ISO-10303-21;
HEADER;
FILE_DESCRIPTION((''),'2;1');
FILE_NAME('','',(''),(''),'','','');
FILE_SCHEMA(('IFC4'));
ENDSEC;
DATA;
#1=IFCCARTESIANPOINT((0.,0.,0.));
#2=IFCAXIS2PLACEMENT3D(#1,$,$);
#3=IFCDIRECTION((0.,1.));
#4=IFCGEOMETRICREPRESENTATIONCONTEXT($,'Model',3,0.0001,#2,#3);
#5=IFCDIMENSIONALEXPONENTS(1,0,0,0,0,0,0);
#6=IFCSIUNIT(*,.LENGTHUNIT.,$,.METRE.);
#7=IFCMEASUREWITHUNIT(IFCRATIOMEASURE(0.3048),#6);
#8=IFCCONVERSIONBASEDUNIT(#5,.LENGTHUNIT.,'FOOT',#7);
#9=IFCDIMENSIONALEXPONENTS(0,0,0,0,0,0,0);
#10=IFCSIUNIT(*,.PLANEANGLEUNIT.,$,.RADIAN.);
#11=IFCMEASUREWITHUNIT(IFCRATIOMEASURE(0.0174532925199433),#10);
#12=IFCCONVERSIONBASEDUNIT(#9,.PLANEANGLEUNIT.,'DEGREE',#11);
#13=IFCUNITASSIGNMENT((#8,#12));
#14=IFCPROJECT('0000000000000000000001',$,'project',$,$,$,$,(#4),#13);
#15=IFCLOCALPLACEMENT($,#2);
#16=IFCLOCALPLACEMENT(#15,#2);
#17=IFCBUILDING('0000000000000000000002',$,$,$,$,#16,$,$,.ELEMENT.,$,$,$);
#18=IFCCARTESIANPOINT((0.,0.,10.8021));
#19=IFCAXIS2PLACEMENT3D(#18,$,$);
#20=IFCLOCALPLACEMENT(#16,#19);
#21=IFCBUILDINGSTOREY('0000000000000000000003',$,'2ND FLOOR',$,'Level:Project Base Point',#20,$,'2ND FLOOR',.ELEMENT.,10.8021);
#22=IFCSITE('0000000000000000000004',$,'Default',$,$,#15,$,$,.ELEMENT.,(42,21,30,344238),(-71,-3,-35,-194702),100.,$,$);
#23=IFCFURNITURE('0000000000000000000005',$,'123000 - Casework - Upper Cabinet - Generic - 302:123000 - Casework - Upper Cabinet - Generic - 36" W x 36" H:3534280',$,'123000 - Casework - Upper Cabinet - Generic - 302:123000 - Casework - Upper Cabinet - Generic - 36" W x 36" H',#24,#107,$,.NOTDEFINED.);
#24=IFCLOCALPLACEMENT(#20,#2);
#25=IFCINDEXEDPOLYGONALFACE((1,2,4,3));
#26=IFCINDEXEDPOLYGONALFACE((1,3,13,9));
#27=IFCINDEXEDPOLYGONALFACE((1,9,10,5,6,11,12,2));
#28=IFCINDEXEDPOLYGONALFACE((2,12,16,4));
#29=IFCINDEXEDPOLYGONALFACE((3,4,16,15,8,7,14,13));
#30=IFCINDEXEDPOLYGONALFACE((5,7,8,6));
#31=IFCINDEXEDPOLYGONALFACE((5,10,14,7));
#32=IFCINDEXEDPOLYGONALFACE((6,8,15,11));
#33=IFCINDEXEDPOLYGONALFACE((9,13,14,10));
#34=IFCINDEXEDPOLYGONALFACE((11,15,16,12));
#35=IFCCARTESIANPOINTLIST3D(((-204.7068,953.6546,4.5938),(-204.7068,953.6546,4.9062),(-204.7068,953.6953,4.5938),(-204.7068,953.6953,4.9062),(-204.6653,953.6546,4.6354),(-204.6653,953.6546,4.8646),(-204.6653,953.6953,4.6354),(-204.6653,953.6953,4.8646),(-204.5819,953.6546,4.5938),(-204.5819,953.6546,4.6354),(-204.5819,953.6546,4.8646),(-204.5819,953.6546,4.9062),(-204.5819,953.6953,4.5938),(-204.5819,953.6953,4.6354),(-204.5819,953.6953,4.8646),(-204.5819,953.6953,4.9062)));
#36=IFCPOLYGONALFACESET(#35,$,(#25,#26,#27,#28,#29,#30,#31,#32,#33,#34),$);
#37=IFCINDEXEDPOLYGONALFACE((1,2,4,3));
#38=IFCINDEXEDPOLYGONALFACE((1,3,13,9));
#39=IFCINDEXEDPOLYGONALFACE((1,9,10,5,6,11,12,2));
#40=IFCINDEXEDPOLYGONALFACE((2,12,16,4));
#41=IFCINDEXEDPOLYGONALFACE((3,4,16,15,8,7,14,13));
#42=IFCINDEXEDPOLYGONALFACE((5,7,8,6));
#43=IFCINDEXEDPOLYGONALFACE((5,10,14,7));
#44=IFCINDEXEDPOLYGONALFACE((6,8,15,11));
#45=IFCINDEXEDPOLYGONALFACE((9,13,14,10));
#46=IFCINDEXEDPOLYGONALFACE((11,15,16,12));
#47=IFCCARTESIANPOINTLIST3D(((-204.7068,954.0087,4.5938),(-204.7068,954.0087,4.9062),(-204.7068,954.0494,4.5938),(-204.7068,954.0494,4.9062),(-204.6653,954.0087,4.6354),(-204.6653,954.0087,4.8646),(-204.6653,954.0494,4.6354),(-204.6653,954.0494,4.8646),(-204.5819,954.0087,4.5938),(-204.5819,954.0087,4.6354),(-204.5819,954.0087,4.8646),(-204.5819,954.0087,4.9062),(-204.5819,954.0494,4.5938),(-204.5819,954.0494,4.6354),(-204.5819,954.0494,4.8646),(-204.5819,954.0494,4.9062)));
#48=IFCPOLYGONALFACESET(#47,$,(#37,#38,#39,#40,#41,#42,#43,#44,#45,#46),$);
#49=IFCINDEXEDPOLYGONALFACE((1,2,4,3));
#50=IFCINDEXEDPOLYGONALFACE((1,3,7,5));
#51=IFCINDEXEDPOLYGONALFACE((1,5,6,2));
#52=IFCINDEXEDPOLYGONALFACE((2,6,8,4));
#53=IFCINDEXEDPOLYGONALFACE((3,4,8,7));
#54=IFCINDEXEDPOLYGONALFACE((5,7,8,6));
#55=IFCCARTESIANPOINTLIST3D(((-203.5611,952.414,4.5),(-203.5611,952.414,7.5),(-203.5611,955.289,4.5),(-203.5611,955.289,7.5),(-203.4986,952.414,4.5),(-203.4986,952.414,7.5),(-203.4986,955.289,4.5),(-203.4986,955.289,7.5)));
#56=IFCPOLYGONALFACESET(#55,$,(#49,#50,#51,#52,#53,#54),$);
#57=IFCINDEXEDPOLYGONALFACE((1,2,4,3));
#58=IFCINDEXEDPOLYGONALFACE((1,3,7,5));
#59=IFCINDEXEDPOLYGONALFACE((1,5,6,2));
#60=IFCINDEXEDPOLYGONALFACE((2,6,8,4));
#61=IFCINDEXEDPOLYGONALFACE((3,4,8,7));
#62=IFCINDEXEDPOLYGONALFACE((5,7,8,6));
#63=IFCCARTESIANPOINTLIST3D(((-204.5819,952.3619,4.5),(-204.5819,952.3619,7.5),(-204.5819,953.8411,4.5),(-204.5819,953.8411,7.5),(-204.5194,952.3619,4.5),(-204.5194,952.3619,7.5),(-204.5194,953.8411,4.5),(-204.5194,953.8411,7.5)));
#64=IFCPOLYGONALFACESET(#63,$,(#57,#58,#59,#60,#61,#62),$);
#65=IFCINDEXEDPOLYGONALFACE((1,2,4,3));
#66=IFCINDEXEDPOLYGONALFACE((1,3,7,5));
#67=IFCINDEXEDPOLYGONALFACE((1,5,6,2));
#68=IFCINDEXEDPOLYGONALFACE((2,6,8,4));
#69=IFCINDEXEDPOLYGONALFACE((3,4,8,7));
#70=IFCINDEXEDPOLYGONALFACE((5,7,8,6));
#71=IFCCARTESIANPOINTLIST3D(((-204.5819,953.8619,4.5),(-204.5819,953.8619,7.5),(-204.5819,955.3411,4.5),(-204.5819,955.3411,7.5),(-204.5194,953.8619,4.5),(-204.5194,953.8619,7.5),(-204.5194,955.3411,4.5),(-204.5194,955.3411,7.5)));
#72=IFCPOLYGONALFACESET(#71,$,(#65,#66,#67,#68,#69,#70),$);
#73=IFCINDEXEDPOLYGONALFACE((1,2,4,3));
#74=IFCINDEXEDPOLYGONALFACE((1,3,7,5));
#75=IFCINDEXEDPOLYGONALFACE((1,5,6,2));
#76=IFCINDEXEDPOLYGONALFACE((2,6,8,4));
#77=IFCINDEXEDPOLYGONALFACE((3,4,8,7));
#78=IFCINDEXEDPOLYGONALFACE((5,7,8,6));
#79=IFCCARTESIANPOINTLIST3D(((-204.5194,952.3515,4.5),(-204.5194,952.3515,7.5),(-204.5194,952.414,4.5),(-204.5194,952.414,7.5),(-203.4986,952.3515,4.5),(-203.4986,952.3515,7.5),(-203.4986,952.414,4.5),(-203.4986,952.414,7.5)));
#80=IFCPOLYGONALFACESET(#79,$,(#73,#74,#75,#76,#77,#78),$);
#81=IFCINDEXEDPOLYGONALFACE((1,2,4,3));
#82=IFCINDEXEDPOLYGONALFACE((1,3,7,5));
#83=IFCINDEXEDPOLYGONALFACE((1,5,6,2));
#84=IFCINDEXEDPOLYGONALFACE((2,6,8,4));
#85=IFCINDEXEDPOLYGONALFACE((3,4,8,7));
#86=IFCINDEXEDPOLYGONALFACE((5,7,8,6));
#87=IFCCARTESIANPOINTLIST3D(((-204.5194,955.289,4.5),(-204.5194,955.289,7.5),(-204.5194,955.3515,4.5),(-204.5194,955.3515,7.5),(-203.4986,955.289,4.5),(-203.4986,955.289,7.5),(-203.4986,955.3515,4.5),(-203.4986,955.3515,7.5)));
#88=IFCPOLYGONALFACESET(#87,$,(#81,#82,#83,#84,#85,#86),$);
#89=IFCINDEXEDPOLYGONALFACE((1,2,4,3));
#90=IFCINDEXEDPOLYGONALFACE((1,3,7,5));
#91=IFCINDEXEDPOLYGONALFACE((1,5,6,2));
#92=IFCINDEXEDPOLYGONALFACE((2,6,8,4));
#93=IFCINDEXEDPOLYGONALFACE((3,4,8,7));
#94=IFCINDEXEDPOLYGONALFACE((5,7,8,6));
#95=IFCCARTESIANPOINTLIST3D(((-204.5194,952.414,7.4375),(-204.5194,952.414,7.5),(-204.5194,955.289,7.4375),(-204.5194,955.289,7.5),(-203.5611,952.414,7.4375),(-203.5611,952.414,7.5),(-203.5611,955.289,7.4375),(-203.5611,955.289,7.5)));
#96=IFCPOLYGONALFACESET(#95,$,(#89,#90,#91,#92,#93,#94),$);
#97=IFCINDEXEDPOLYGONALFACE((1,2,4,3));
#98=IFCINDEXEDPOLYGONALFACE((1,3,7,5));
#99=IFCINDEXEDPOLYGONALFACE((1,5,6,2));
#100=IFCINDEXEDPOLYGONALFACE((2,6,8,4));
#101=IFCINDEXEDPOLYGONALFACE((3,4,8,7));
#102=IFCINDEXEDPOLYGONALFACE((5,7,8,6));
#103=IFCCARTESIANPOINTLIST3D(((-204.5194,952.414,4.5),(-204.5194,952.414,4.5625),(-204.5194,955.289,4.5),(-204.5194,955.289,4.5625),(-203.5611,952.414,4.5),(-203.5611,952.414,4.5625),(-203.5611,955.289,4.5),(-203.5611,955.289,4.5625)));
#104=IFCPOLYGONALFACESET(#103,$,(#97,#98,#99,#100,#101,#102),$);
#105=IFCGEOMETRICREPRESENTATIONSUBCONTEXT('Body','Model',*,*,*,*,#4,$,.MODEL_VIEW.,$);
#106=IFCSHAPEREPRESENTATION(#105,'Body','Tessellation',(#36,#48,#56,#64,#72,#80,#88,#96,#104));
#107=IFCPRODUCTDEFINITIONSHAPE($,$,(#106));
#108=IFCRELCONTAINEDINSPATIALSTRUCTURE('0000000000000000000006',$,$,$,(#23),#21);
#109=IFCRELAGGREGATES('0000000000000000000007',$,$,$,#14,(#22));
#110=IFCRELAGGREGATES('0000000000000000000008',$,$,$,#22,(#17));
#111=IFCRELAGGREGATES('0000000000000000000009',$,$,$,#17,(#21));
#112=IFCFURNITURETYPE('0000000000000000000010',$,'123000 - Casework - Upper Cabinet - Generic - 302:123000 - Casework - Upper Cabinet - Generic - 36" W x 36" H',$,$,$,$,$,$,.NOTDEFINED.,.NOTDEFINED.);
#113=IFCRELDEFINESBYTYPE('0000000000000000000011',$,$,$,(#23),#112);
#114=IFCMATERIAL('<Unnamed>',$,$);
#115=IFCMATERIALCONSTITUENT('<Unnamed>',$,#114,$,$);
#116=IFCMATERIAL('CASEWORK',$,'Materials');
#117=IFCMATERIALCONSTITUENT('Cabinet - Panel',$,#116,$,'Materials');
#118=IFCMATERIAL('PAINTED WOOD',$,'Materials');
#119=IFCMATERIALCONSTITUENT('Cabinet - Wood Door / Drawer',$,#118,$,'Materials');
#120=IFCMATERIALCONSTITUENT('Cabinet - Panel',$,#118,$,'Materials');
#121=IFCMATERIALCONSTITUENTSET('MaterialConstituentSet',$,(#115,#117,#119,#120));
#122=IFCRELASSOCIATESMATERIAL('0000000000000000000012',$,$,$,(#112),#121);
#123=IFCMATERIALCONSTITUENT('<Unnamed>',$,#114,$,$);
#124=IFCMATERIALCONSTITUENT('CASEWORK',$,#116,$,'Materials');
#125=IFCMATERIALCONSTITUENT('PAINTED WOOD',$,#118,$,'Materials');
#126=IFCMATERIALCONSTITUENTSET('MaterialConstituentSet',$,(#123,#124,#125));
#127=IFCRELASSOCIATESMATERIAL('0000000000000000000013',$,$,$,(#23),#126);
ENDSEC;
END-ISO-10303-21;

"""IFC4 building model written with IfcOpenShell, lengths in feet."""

from ifc_helpers import new_model, entity, si_unit, converted_unit, direction, frame, frame_2d, origin, origin_2d_with_axis, place, context, subcontext, project, spatial, polyline, rectangle, outline, extrude, source, transform, mapped, material, constituent, constituent_set, type_object, type_shapes, element, save


model = new_model("IFC4")

# Units and contexts
model_context = context("Model", 3, precision=0.0001, world=origin(), true_north=direction((0.0, 1.0)))
body_context = subcontext(model_context, "Body", "Model", "MODEL_VIEW")
ifc_project = project(units=[converted_unit("LENGTHUNIT", "FOOT", entity("IfcRatioMeasure", 0.3048), si_unit("LENGTHUNIT", "METRE"), dimensions=[1, 0, 0, 0, 0, 0, 0]), converted_unit("PLANEANGLEUNIT", "DEGREE", entity("IfcRatioMeasure", 0.0174532925199433), si_unit("PLANEANGLEUNIT", "RADIAN"), dimensions=[0, 0, 0, 0, 0, 0, 0])], contexts=[model_context])

# Site, building, storey
site_placement = place(None, origin())
site = spatial("IfcSite", under=ifc_project, at=site_placement, Name="Default", CompositionType="ELEMENT", RefLatitude=(42, 21, 30, 344238), RefLongitude=(-71, -3, -35, -194702), RefElevation=100.0)
building_placement = place(site_placement, origin())
building = spatial("IfcBuilding", under=site, at=building_placement, CompositionType="ELEMENT")
storey_placement = place(building_placement, frame((0.0, 0.0, 10.8021)))
storey = spatial("IfcBuildingStorey", under=building, at=storey_placement, Name="2ND FLOOR", ObjectType="Level:Project Base Point", LongName="2ND FLOOR", CompositionType="ELEMENT", Elevation=10.8021)

# Furniture
ifc_material_1 = material(Name="<Unnamed>")
ifc_material_2 = material(Name="CASEWORK", Category="Materials")
ifc_material_3 = material(Name="PAINTED WOOD", Category="Materials")
ifc_constituent_1 = constituent(ifc_material_1, Name="<Unnamed>")
ifc_constituent_2 = constituent(ifc_material_2, Name="CASEWORK", Category="Materials")
ifc_constituent_3 = constituent(ifc_material_3, Name="PAINTED WOOD", Category="Materials")
ifc_constituent_set_1 = constituent_set(constituents=[ifc_constituent_1, ifc_constituent_2, ifc_constituent_3], Name="MaterialConstituentSet")
ifc_constituent_4 = constituent(ifc_material_1, Name="<Unnamed>")
ifc_constituent_5 = constituent(ifc_material_2, Name="Cabinet - Panel", Category="Materials")
ifc_constituent_6 = constituent(ifc_material_3, Name="Cabinet - Wood Door / Drawer", Category="Materials")
ifc_constituent_7 = constituent(ifc_material_3, Name="Cabinet - Panel", Category="Materials")
ifc_constituent_set_2 = constituent_set(constituents=[ifc_constituent_4, ifc_constituent_5, ifc_constituent_6, ifc_constituent_7], Name="MaterialConstituentSet")
furniture_type_1 = type_object("IfcFurnitureType", Name="123000 - Casework - Upper Cabinet - Generic - 302:123000 - Casework - Upper Cabinet - Generic - 36\" W x 36\" H", AssemblyPlace="NOTDEFINED", PredefinedType="NOTDEFINED", material=ifc_constituent_set_2)
shared_shape_1 = source(origin(), body_context, "Body", "SweptSolid", [
    extrude(outline(polyline([(-0.0521, -0.1146), (-0.0521, -0.1562), (0.0729, -0.1562), (0.0729, 0.1562), (-0.0521, 0.1562), (-0.0521, 0.1146), (0.0313, 0.1146), (0.0313, -0.1146), (-0.0521, -0.1146)])), frame((1.303, 1.1354, 0.25), z_axis=(-1.0, 0.0, 0.0), x_axis=(0.0, 1.0, 0.0)), (0.0, 0.0, -1.0), 0.0407),
    extrude(outline(polyline([(-0.0521, -0.1146), (-0.0521, -0.1562), (0.0729, -0.1562), (0.0729, 0.1562), (-0.0521, 0.1562), (-0.0521, 0.1146), (0.0313, 0.1146), (0.0313, -0.1146), (-0.0521, -0.1146)])), frame((1.6572, 1.1354, 0.25), z_axis=(-1.0, 0.0, 0.0), x_axis=(0.0, 1.0, 0.0)), (0.0, 0.0, -1.0), 0.0407),
    extrude(rectangle(XDim=2.875, YDim=0.0625, at=frame_2d((0.0, 0.0), x_axis=(1.0, 0.0))), frame((1.5, 0.0313, 0.0), z_axis=(0.0, 0.0, 1.0), x_axis=(-1.0, 0.0, 0.0)), (0.0, 0.0, 1.0), 3.0),
    extrude(rectangle(XDim=1.4792, YDim=0.0625, at=origin_2d_with_axis()), frame((0.75, 1.0521, 0.0)), (0.0, 0.0, 1.0), 3.0),
    extrude(rectangle(XDim=1.4792, YDim=0.0625, at=origin_2d_with_axis()), frame((2.25, 1.0521, 0.0)), (0.0, 0.0, 1.0), 3.0),
    extrude(rectangle(XDim=1.0208, YDim=0.0625, at=origin_2d_with_axis()), frame((0.0312, 0.5104, 0.0), z_axis=(0.0, 0.0, 1.0), x_axis=(0.0, 1.0, 0.0)), (0.0, 0.0, 1.0), 3.0),
    extrude(rectangle(XDim=1.0208, YDim=0.0625, at=frame_2d((0.0, 0.0), x_axis=(1.0, 0.0))), frame((2.9688, 0.5104, 0.0), z_axis=(0.0, 0.0, 1.0), x_axis=(0.0, 1.0, 0.0)), (0.0, 0.0, 1.0), 3.0),
    extrude(rectangle(XDim=0.9583, YDim=2.875, at=frame_2d((0.0, 0.0), x_axis=(1.0, 0.0))), frame((1.5, 0.5417, 2.9375), z_axis=(0.0, 0.0, 1.0), x_axis=(0.0, 1.0, 0.0)), (0.0, 0.0, 1.0), 0.0625),
    extrude(rectangle(XDim=0.9583, YDim=2.875, at=frame_2d((0.0, 0.0), x_axis=(1.0, 0.0))), frame((1.5, 0.5417, 0.0), z_axis=(0.0, 0.0, 1.0), x_axis=(0.0, 1.0, 0.0)), (0.0, 0.0, 1.0), 0.0625),
])
type_shapes(furniture_type_1, [shared_shape_1])
furniture_1_placement = place(storey_placement, frame((-203.4986, 952.3515, 4.5), z_axis=(0.0, 0.0, 1.0), x_axis=(0.0, 1.0, 0.0)))
element("IfcFurniture", 1, at=furniture_1_placement, inside=storey, type_object=furniture_type_1, material=ifc_constituent_set_1, Name="123000 - Casework - Upper Cabinet - Generic - 302:123000 - Casework - Upper Cabinet - Generic - 36\" W x 36\" H:3534280", ObjectType="123000 - Casework - Upper Cabinet - Generic - 302:123000 - Casework - Upper Cabinet - Generic - 36\" W x 36\" H", PredefinedType="NOTDEFINED", context=body_context, shape_type="MappedRepresentation", body=[
    mapped(shared_shape_1, transform((0.0, 0.0, 0.0), scale=1.0)),
])

save(model, "model.ifc")
